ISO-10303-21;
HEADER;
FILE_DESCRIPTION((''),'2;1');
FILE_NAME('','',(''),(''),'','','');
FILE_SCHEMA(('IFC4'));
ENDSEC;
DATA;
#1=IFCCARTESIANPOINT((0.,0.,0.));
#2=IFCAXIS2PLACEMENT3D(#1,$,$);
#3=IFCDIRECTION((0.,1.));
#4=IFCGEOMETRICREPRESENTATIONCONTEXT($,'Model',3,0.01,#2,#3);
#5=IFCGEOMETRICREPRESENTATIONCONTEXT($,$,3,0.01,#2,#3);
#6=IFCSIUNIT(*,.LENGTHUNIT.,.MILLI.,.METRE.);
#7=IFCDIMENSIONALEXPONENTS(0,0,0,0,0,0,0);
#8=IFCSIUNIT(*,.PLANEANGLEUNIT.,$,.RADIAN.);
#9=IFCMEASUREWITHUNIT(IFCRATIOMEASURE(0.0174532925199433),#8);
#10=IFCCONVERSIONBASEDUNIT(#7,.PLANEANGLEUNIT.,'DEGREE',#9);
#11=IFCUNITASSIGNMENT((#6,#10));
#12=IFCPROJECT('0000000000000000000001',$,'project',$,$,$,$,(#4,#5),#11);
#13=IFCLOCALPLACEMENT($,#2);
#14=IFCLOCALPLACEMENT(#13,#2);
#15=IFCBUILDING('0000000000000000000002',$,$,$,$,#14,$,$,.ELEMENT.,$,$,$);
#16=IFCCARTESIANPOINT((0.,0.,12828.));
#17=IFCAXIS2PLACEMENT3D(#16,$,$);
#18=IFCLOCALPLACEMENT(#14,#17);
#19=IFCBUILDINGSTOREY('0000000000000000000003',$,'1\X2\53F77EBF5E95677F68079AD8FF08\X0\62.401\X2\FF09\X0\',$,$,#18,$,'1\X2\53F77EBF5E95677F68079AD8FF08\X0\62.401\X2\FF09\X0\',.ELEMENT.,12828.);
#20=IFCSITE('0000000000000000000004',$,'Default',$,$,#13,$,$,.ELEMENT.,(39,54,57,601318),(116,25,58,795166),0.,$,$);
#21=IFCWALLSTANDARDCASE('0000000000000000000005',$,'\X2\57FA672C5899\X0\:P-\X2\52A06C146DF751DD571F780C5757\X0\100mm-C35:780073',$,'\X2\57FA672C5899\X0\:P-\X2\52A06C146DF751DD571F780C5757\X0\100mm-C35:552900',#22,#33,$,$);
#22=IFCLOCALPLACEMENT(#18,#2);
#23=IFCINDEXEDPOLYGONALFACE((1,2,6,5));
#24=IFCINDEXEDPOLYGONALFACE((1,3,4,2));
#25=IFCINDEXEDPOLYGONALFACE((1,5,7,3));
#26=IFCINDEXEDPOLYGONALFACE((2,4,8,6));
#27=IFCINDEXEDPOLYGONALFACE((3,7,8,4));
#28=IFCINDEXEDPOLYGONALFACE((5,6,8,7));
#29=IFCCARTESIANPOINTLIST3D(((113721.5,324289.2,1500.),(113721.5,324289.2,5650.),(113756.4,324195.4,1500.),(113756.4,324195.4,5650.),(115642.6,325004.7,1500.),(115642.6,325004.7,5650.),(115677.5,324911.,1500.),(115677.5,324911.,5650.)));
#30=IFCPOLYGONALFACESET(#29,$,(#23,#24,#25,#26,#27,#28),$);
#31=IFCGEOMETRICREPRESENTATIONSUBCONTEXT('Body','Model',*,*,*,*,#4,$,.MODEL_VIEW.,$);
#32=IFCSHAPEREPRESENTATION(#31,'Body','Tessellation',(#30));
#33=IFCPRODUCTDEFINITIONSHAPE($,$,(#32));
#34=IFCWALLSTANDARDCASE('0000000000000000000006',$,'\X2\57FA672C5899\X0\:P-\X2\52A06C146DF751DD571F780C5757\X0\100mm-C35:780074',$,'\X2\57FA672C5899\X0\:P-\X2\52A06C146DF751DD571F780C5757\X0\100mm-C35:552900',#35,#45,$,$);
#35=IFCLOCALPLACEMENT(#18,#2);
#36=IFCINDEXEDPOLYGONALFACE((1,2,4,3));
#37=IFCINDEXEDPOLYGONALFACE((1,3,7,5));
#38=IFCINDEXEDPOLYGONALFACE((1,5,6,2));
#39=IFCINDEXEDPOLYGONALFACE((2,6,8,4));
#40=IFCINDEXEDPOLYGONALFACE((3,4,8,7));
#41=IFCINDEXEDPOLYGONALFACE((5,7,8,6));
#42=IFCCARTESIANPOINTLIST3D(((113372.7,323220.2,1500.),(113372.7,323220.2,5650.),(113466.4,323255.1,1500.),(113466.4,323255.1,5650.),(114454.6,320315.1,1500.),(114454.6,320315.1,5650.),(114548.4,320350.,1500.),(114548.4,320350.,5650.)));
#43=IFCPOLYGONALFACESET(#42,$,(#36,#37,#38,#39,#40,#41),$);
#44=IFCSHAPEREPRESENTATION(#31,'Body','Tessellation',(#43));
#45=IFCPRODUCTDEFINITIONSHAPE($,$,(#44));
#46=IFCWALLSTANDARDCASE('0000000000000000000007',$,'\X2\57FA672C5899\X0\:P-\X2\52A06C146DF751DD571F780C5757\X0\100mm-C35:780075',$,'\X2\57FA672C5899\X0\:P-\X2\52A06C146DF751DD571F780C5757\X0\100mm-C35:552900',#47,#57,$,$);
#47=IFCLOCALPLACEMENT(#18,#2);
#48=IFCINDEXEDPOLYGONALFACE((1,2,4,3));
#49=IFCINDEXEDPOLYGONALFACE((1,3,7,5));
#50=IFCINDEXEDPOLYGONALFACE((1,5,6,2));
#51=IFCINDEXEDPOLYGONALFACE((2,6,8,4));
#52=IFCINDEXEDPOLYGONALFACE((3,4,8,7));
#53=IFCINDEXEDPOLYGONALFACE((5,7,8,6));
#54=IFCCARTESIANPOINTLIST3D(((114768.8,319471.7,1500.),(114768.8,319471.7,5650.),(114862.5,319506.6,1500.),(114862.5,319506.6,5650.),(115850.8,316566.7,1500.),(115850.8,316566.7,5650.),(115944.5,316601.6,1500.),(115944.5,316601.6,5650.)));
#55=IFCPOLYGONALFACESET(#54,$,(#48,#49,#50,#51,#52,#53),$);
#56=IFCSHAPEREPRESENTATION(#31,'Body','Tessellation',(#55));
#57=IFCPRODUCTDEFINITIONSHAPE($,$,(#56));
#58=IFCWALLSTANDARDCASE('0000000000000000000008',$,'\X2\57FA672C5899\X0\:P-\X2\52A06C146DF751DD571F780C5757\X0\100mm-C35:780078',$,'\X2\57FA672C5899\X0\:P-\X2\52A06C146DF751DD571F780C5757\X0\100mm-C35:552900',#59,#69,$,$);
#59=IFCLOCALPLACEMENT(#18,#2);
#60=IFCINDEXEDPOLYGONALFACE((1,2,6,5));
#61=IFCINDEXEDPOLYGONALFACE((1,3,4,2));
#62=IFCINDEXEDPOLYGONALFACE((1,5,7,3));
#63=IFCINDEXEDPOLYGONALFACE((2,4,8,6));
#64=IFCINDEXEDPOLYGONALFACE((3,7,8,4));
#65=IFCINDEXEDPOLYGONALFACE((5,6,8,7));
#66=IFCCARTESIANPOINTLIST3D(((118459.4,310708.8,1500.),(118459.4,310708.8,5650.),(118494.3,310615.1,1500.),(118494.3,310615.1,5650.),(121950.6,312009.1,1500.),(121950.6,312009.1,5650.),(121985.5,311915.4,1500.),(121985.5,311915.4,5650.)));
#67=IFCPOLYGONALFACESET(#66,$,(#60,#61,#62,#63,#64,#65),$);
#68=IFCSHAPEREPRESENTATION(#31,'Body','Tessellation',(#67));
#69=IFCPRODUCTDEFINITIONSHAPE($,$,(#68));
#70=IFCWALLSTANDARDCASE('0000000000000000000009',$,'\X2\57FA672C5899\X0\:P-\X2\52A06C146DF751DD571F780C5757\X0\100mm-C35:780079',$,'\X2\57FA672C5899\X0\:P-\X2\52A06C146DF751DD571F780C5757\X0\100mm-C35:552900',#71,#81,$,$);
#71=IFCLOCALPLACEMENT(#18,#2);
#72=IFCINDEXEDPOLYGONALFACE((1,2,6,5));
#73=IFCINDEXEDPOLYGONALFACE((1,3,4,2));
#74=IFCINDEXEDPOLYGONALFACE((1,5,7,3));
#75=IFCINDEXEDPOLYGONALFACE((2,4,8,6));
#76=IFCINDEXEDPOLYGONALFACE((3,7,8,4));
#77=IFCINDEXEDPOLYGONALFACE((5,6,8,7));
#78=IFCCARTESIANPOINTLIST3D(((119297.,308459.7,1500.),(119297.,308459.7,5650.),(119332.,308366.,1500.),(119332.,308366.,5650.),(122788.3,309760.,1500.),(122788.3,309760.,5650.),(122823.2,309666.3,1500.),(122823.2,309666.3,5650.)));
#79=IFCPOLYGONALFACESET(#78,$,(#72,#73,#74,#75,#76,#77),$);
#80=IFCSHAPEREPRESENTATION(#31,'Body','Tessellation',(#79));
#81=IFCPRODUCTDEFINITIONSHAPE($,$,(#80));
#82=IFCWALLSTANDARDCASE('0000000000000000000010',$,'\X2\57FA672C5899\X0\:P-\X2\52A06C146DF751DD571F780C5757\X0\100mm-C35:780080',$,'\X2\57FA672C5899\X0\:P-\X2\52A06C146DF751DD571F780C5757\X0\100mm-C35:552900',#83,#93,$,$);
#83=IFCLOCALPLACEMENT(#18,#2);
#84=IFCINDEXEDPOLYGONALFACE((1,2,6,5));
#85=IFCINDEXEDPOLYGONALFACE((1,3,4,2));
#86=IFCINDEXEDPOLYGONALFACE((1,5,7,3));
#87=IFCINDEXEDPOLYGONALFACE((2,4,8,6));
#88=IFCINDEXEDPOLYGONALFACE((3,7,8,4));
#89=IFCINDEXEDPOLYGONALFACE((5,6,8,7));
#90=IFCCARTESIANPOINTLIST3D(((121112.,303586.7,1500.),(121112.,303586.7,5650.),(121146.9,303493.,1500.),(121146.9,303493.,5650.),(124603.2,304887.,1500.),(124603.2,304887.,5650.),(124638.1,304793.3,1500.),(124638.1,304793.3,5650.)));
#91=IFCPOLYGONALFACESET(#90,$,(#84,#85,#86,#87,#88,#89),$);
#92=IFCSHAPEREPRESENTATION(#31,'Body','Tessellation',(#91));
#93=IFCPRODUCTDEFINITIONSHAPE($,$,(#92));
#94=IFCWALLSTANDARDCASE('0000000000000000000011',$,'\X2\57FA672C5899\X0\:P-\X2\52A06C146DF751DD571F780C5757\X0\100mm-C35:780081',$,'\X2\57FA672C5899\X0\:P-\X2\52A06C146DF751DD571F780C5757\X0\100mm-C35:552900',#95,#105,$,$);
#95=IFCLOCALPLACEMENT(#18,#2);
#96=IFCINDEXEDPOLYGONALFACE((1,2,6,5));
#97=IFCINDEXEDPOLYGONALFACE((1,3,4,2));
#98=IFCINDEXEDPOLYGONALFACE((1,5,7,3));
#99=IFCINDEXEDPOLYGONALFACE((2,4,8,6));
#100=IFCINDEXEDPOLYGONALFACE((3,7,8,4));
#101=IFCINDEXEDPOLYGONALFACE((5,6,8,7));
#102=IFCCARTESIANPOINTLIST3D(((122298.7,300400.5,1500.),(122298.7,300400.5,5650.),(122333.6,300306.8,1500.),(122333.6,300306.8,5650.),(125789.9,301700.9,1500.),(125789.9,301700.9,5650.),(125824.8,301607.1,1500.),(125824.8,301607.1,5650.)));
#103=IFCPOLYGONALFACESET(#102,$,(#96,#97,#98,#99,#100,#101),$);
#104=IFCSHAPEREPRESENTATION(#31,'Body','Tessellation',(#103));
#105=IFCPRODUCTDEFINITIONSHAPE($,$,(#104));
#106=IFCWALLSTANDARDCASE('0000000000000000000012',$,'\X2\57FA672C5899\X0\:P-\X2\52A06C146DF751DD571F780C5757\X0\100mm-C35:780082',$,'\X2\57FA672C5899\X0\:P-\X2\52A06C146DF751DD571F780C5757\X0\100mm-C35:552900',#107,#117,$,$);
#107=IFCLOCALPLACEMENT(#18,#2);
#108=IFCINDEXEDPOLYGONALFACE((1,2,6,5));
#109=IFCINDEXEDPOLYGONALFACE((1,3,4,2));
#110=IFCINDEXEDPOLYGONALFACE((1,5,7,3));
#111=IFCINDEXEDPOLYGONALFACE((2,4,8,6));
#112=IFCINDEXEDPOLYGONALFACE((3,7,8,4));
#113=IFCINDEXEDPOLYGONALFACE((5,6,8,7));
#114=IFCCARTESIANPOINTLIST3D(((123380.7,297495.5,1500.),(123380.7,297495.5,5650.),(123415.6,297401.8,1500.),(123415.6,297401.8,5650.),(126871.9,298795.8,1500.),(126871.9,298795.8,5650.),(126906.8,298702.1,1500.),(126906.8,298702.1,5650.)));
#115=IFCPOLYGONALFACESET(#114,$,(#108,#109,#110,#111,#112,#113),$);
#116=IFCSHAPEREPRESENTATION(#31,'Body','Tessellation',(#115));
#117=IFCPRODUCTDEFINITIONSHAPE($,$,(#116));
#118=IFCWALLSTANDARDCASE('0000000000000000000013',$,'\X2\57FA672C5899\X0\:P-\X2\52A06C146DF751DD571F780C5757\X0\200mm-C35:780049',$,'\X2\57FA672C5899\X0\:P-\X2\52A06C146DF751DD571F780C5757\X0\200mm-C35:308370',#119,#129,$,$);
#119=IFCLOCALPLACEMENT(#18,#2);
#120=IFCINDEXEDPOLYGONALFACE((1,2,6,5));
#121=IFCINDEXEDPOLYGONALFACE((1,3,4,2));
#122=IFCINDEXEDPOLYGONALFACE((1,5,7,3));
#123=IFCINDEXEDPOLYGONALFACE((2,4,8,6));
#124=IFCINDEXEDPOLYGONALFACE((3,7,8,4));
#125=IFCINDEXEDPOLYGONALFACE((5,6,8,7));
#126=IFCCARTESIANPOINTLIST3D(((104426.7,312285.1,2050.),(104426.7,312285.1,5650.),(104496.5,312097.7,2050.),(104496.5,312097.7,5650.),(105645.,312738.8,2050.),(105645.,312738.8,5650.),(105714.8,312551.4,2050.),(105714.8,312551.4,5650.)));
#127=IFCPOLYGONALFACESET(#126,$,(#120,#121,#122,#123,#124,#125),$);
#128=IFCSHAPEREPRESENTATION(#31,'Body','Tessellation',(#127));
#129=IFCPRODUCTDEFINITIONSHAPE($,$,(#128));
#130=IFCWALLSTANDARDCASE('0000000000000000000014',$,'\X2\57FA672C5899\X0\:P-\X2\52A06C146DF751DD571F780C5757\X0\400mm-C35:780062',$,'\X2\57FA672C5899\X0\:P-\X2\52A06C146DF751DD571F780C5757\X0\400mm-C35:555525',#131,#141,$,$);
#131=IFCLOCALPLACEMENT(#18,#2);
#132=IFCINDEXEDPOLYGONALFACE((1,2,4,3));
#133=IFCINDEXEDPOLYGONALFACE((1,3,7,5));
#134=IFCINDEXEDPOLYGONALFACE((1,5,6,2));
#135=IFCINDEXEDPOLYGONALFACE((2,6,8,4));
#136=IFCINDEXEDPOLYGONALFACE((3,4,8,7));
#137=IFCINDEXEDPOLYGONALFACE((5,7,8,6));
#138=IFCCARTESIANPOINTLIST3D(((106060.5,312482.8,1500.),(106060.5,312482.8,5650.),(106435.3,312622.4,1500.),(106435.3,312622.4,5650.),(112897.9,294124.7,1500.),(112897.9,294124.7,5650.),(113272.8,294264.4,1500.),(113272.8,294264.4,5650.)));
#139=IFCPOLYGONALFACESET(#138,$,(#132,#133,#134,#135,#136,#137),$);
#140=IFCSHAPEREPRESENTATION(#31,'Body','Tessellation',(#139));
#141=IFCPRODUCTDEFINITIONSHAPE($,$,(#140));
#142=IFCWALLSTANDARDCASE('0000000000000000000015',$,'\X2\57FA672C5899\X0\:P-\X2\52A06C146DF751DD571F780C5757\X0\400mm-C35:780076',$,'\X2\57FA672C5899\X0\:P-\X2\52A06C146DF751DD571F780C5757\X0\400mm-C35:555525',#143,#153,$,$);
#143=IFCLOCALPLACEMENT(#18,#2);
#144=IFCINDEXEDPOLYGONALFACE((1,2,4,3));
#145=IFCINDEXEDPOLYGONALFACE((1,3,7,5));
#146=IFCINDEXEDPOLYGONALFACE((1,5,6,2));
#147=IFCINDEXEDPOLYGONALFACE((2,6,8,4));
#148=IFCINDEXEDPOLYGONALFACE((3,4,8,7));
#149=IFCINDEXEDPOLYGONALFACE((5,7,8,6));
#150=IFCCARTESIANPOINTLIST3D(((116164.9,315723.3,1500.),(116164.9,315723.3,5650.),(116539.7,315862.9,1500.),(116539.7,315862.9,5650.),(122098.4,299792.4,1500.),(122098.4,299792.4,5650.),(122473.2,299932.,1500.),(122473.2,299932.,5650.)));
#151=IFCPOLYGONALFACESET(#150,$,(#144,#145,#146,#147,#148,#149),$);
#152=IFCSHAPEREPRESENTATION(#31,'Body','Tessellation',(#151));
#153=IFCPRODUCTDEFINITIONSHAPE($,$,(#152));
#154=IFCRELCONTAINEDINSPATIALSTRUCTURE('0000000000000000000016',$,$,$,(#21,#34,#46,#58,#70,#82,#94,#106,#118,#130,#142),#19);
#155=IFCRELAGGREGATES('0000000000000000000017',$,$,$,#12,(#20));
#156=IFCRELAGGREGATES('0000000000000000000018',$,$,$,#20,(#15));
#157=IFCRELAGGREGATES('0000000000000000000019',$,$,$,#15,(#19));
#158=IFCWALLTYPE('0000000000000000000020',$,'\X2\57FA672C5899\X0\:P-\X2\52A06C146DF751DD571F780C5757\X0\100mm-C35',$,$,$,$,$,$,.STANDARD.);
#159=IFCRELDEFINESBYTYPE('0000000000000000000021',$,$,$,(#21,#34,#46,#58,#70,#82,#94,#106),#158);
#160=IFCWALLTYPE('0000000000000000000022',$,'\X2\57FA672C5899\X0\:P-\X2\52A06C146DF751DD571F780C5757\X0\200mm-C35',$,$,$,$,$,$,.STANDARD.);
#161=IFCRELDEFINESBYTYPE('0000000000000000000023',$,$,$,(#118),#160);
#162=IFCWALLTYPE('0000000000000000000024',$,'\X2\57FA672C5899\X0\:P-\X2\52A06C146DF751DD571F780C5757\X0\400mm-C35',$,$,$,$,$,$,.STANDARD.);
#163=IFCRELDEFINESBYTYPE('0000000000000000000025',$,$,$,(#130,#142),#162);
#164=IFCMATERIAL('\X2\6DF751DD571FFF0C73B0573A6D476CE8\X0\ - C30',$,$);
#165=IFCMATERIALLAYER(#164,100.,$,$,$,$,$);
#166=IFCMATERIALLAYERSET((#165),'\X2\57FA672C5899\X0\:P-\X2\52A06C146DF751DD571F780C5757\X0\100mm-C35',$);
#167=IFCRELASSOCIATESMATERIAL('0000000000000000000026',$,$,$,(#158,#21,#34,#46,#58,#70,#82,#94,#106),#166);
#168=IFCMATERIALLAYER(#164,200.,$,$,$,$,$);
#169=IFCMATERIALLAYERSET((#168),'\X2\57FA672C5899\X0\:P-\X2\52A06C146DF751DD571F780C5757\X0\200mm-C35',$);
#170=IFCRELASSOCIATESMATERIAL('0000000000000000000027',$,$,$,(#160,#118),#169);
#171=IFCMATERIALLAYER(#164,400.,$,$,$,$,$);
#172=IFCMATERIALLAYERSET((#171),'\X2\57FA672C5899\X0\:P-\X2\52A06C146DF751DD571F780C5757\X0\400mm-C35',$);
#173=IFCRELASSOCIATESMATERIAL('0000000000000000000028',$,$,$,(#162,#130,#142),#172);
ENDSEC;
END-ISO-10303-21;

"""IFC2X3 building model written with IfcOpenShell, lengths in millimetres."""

from ifc_helpers import new_model, entity, si_unit, converted_unit, direction, frame, frame_2d, origin, place, context, subcontext, project, spatial, polyline, rectangle, extrude, clip, bounded_halfspace, material, layer, layer_set, layer_usage, type_object, element, save


model = new_model("IFC2X3")

# Units and contexts
model_context = context("Model", 3, precision=0.01, world=origin(), true_north=direction((0.0, 1.0)))
context_of_model = context(None, 3, precision=0.01, world=origin(), true_north=direction((0.0, 1.0)))
body_context = subcontext(model_context, "Body", "Model", "MODEL_VIEW")
ifc_project = project(units=[si_unit("LENGTHUNIT", "METRE", prefix="MILLI"), converted_unit("PLANEANGLEUNIT", "DEGREE", entity("IfcRatioMeasure", 0.0174532925199433), si_unit("PLANEANGLEUNIT", "RADIAN"), dimensions=[0, 0, 0, 0, 0, 0, 0])], contexts=[model_context, context_of_model])

# Site, building, storey
site_placement = place(None, origin())
site = spatial("IfcSite", under=ifc_project, at=site_placement, Name="Default", CompositionType="ELEMENT", RefLatitude=(39, 54, 57, 601318), RefLongitude=(116, 25, 58, 795166), RefElevation=0.0)
building_placement = place(site_placement, origin())
building = spatial("IfcBuilding", under=site, at=building_placement, CompositionType="ELEMENT")
storey_placement = place(building_placement, frame((0.0, 0.0, 12828.0)))
storey = spatial("IfcBuildingStorey", under=building, at=storey_placement, Name="1号线底板标高（62.401）", LongName="1号线底板标高（62.401）", CompositionType="ELEMENT", Elevation=12828.0)

# Walls
ifc_material_1 = material(Name="混凝土，现场浇注 - C30")
ifc_layer_1 = layer(ifc_material_1, 100.0)
ifc_layer_set_1 = layer_set([ifc_layer_1], Name="基本墙:P-加气混凝土砌块100mm-C35")
wall_type_1 = type_object("IfcWallType", Name="基本墙:P-加气混凝土砌块100mm-C35", PredefinedType="STANDARD", material=ifc_layer_set_1)
ifc_layer_usage_1 = layer_usage(ifc_layer_set_1, "AXIS2", "NEGATIVE", 50.0)
wall_1_placement = place(storey_placement, frame((113738.9, 324242.3, 1500.0), z_axis=(0.0, 0.0, 1.0), x_axis=(0.937112, 0.349028, 0.0)))
element("IfcWallStandardCase", 1, at=wall_1_placement, inside=storey, type_object=wall_type_1, material=ifc_layer_usage_1, Name="基本墙:P-加气混凝土砌块100mm-C35:780073", ObjectType="基本墙:P-加气混凝土砌块100mm-C35:552900", context=body_context, shape_type="Clipping", body=[
    clip(extrude(rectangle(XDim=2050.0, YDim=100.0, at=frame_2d((1025.0, 0.0), x_axis=(-1.0, 0.0))), origin(), (0.0, 0.0, 1.0), 4150.0), bounded_halfspace(frame((0.0, -50.0, 4150.0), z_axis=(0.0, 0.0, -1.0), x_axis=(1.0, 0.0, 0.0)), True, frame((0.0, -50.0, 4150.0)), polyline([(0.0, 0.0), (2050.0, 0.0), (2050.0, 100.0), (0.0, 100.0), (0.0, 0.0)]))),
])
ifc_layer_usage_2 = layer_usage(ifc_layer_set_1, "AXIS2", "NEGATIVE", 50.0)
wall_2_placement = place(storey_placement, frame((113419.5, 323237.6, 1500.0), z_axis=(0.0, 0.0, 1.0), x_axis=(0.349028, -0.937112, 0.0)))
element("IfcWallStandardCase", 2, at=wall_2_placement, inside=storey, type_object=wall_type_1, material=ifc_layer_usage_2, Name="基本墙:P-加气混凝土砌块100mm-C35:780074", ObjectType="基本墙:P-加气混凝土砌块100mm-C35:552900", context=body_context, shape_type="Clipping", body=[
    clip(extrude(rectangle(XDim=3100.0, YDim=100.0, at=frame_2d((1550.0, 0.0), x_axis=(-1.0, 0.0))), origin(), (0.0, 0.0, 1.0), 4150.0), bounded_halfspace(frame((0.0, -50.0, 4150.0), z_axis=(0.0, 0.0, -1.0), x_axis=(0.0, 1.0, 0.0)), True, frame((0.0, -50.0, 4150.0)), polyline([(0.0, 0.0), (3100.0, 0.0), (3100.0, 100.0), (0.0, 100.0), (0.0, 0.0)]))),
])
ifc_layer_usage_3 = layer_usage(ifc_layer_set_1, "AXIS2", "NEGATIVE", 50.0)
wall_3_placement = place(storey_placement, frame((114815.6, 319489.2, 1500.0), z_axis=(0.0, 0.0, 1.0), x_axis=(0.349028, -0.937112, 0.0)))
element("IfcWallStandardCase", 3, at=wall_3_placement, inside=storey, type_object=wall_type_1, material=ifc_layer_usage_3, Name="基本墙:P-加气混凝土砌块100mm-C35:780075", ObjectType="基本墙:P-加气混凝土砌块100mm-C35:552900", context=body_context, shape_type="Clipping", body=[
    clip(extrude(rectangle(XDim=3100.0, YDim=100.0, at=frame_2d((1550.0, 0.0), x_axis=(-1.0, 0.0))), origin(), (0.0, 0.0, 1.0), 4150.0), bounded_halfspace(frame((0.0, -50.0, 4150.0), z_axis=(0.0, 0.0, -1.0), x_axis=(0.0, 1.0, 0.0)), True, frame((0.0, -50.0, 4150.0)), polyline([(0.0, 0.0), (3100.0, 0.0), (3100.0, 100.0), (0.0, 100.0), (0.0, 0.0)]))),
])
ifc_layer_usage_4 = layer_usage(ifc_layer_set_1, "AXIS2", "NEGATIVE", 50.0)
wall_4_placement = place(storey_placement, frame((118476.8, 310661.9, 1500.0), z_axis=(0.0, 0.0, 1.0), x_axis=(0.937112, 0.349028, 0.0)))
element("IfcWallStandardCase", 4, at=wall_4_placement, inside=storey, type_object=wall_type_1, material=ifc_layer_usage_4, Name="基本墙:P-加气混凝土砌块100mm-C35:780078", ObjectType="基本墙:P-加气混凝土砌块100mm-C35:552900", context=body_context, shape_type="Clipping", body=[
    clip(extrude(rectangle(XDim=3725.5, YDim=100.0, at=frame_2d((1862.8, 0.0), x_axis=(-1.0, 0.0))), origin(), (0.0, 0.0, 1.0), 4150.0), bounded_halfspace(frame((0.0, -50.0, 4150.0), z_axis=(0.0, 0.0, -1.0), x_axis=(1.0, 0.0, 0.0)), True, frame((0.0, -50.0, 4150.0)), polyline([(0.0, 0.0), (3725.5, 0.0), (3725.5, 100.0), (0.0, 100.0), (0.0, 0.0)]))),
])
ifc_layer_usage_5 = layer_usage(ifc_layer_set_1, "AXIS2", "NEGATIVE", 50.0)
wall_5_placement = place(storey_placement, frame((119314.5, 308412.9, 1500.0), z_axis=(0.0, 0.0, 1.0), x_axis=(0.937112, 0.349028, 0.0)))
element("IfcWallStandardCase", 5, at=wall_5_placement, inside=storey, type_object=wall_type_1, material=ifc_layer_usage_5, Name="基本墙:P-加气混凝土砌块100mm-C35:780079", ObjectType="基本墙:P-加气混凝土砌块100mm-C35:552900", context=body_context, shape_type="Clipping", body=[
    clip(extrude(rectangle(XDim=3725.5, YDim=100.0, at=frame_2d((1862.8, 0.0), x_axis=(-1.0, 0.0))), origin(), (0.0, 0.0, 1.0), 4150.0), bounded_halfspace(frame((0.0, -50.0, 4150.0), z_axis=(0.0, 0.0, -1.0), x_axis=(1.0, 0.0, 0.0)), True, frame((0.0, -50.0, 4150.0)), polyline([(0.0, 0.0), (3725.5, 0.0), (3725.5, 100.0), (0.0, 100.0), (0.0, 0.0)]))),
])
ifc_layer_usage_6 = layer_usage(ifc_layer_set_1, "AXIS2", "NEGATIVE", 50.0)
wall_6_placement = place(storey_placement, frame((121129.4, 303539.9, 1500.0), z_axis=(0.0, 0.0, 1.0), x_axis=(0.937112, 0.349028, 0.0)))
element("IfcWallStandardCase", 6, at=wall_6_placement, inside=storey, type_object=wall_type_1, material=ifc_layer_usage_6, Name="基本墙:P-加气混凝土砌块100mm-C35:780080", ObjectType="基本墙:P-加气混凝土砌块100mm-C35:552900", context=body_context, shape_type="Clipping", body=[
    clip(extrude(rectangle(XDim=3725.5, YDim=100.0, at=frame_2d((1862.8, 0.0), x_axis=(-1.0, 0.0))), origin(), (0.0, 0.0, 1.0), 4150.0), bounded_halfspace(frame((0.0, -50.0, 4150.0), z_axis=(0.0, 0.0, -1.0), x_axis=(1.0, 0.0, 0.0)), True, frame((0.0, -50.0, 4150.0)), polyline([(0.0, 0.0), (3725.5, 0.0), (3725.5, 100.0), (0.0, 100.0), (0.0, 0.0)]))),
])
ifc_layer_usage_7 = layer_usage(ifc_layer_set_1, "AXIS2", "NEGATIVE", 50.0)
wall_7_placement = place(storey_placement, frame((122316.1, 300353.7, 1500.0), z_axis=(0.0, 0.0, 1.0), x_axis=(0.937112, 0.349028, 0.0)))
element("IfcWallStandardCase", 7, at=wall_7_placement, inside=storey, type_object=wall_type_1, material=ifc_layer_usage_7, Name="基本墙:P-加气混凝土砌块100mm-C35:780081", ObjectType="基本墙:P-加气混凝土砌块100mm-C35:552900", context=body_context, shape_type="Clipping", body=[
    clip(extrude(rectangle(XDim=3725.5, YDim=100.0, at=frame_2d((1862.8, 0.0), x_axis=(-1.0, 0.0))), origin(), (0.0, 0.0, 1.0), 4150.0), bounded_halfspace(frame((0.0, -50.0, 4150.0), z_axis=(0.0, 0.0, -1.0), x_axis=(1.0, 0.0, 0.0)), True, frame((0.0, -50.0, 4150.0)), polyline([(0.0, 0.0), (3725.5, 0.0), (3725.5, 100.0), (0.0, 100.0), (0.0, 0.0)]))),
])
ifc_layer_usage_8 = layer_usage(ifc_layer_set_1, "AXIS2", "NEGATIVE", 50.0)
wall_8_placement = place(storey_placement, frame((123398.1, 297448.6, 1500.0), z_axis=(0.0, 0.0, 1.0), x_axis=(0.937112, 0.349028, 0.0)))
element("IfcWallStandardCase", 8, at=wall_8_placement, inside=storey, type_object=wall_type_1, material=ifc_layer_usage_8, Name="基本墙:P-加气混凝土砌块100mm-C35:780082", ObjectType="基本墙:P-加气混凝土砌块100mm-C35:552900", context=body_context, shape_type="Clipping", body=[
    clip(extrude(rectangle(XDim=3725.5, YDim=100.0, at=frame_2d((1862.8, 0.0), x_axis=(-1.0, 0.0))), origin(), (0.0, 0.0, 1.0), 4150.0), bounded_halfspace(frame((0.0, -50.0, 4150.0), z_axis=(0.0, 0.0, -1.0), x_axis=(1.0, 0.0, 0.0)), True, frame((0.0, -50.0, 4150.0)), polyline([(0.0, 0.0), (3725.5, 0.0), (3725.5, 100.0), (0.0, 100.0), (0.0, 0.0)]))),
])
ifc_layer_2 = layer(ifc_material_1, 200.0)
ifc_layer_set_2 = layer_set([ifc_layer_2], Name="基本墙:P-加气混凝土砌块200mm-C35")
ifc_layer_usage_9 = layer_usage(ifc_layer_set_2, "AXIS2", "NEGATIVE", 100.0)
wall_type_2 = type_object("IfcWallType", Name="基本墙:P-加气混凝土砌块200mm-C35", PredefinedType="STANDARD", material=ifc_layer_set_2)
wall_9_placement = place(storey_placement, frame((105679.9, 312645.1, 2050.0), z_axis=(0.0, 0.0, 1.0), x_axis=(-0.937112, -0.349028, 0.0)))
element("IfcWallStandardCase", 9, at=wall_9_placement, inside=storey, type_object=wall_type_2, material=ifc_layer_usage_9, Name="基本墙:P-加气混凝土砌块200mm-C35:780049", ObjectType="基本墙:P-加气混凝土砌块200mm-C35:308370", context=body_context, shape_type="Clipping", body=[
    clip(extrude(rectangle(XDim=1300.0, YDim=200.0, at=frame_2d((650.0, 0.0), x_axis=(-1.0, 0.0))), origin(), (0.0, 0.0, 1.0), 3600.0), bounded_halfspace(frame((0.0, -100.0, 3600.0), z_axis=(0.0, 0.0, -1.0), x_axis=(-1.0, 0.0, 0.0)), True, frame((0.0, -100.0, 3600.0)), polyline([(0.0, 0.0), (1300.0, 0.0), (1300.0, 200.0), (0.0, 200.0), (0.0, 0.0)]))),
])
ifc_layer_3 = layer(ifc_material_1, 400.0)
ifc_layer_set_3 = layer_set([ifc_layer_3], Name="基本墙:P-加气混凝土砌块400mm-C35")
ifc_layer_usage_10 = layer_usage(ifc_layer_set_3, "AXIS2", "NEGATIVE", 200.0)
wall_type_3 = type_object("IfcWallType", Name="基本墙:P-加气混凝土砌块400mm-C35", PredefinedType="STANDARD", material=ifc_layer_set_3)
wall_10_placement = place(storey_placement, frame((106247.9, 312552.6, 1500.0), z_axis=(0.0, 0.0, 1.0), x_axis=(0.349028, -0.937112, 0.0)))
element("IfcWallStandardCase", 10, at=wall_10_placement, inside=storey, type_object=wall_type_3, material=ifc_layer_usage_10, Name="基本墙:P-加气混凝土砌块400mm-C35:780062", ObjectType="基本墙:P-加气混凝土砌块400mm-C35:555525", context=body_context, shape_type="Clipping", body=[
    clip(extrude(rectangle(XDim=19590.0, YDim=400.0, at=frame_2d((9795.0, 0.0), x_axis=(-1.0, 0.0))), origin(), (0.0, 0.0, 1.0), 4150.0), bounded_halfspace(frame((0.0, -200.0, 4150.0), z_axis=(0.0, 0.0, -1.0), x_axis=(0.0, 1.0, 0.0)), True, frame((0.0, -200.0, 4150.0)), polyline([(0.0, 0.0), (16040.0, 0.0), (16140.0, 0.0), (19590.0, 0.0), (19590.0, 400.0), (0.0, 400.0), (0.0, 0.0)]))),
])
ifc_layer_usage_11 = layer_usage(ifc_layer_set_3, "AXIS2", "NEGATIVE", 200.0)
wall_11_placement = place(storey_placement, frame((116352.3, 315793.1, 1500.0), z_axis=(0.0, 0.0, 1.0), x_axis=(0.349028, -0.937112, 0.0)))
element("IfcWallStandardCase", 11, at=wall_11_placement, inside=storey, type_object=wall_type_3, material=ifc_layer_usage_11, Name="基本墙:P-加气混凝土砌块400mm-C35:780076", ObjectType="基本墙:P-加气混凝土砌块400mm-C35:555525", context=body_context, shape_type="Clipping", body=[
    clip(extrude(rectangle(XDim=17000.0, YDim=400.0, at=frame_2d((8500.0, 0.0), x_axis=(-1.0, 0.0))), origin(), (0.0, 0.0, 1.0), 4150.0), bounded_halfspace(frame((0.0, -200.0, 4150.0), z_axis=(0.0, 0.0, -1.0), x_axis=(0.0, 1.0, 0.0)), True, frame((0.0, -200.0, 4150.0)), polyline([(0.0, 0.0), (17000.0, 0.0), (17000.0, 400.0), (16600.0, 400.0), (16500.0, 400.0), (13200.0, 400.0), (13100.0, 400.0), (8000.0, 400.0), (7900.0, 400.0), (5600.0, 400.0), (5500.0, 400.0), (0.0, 400.0), (0.0, 0.0)]))),
])

save(model, "model.ifc")
